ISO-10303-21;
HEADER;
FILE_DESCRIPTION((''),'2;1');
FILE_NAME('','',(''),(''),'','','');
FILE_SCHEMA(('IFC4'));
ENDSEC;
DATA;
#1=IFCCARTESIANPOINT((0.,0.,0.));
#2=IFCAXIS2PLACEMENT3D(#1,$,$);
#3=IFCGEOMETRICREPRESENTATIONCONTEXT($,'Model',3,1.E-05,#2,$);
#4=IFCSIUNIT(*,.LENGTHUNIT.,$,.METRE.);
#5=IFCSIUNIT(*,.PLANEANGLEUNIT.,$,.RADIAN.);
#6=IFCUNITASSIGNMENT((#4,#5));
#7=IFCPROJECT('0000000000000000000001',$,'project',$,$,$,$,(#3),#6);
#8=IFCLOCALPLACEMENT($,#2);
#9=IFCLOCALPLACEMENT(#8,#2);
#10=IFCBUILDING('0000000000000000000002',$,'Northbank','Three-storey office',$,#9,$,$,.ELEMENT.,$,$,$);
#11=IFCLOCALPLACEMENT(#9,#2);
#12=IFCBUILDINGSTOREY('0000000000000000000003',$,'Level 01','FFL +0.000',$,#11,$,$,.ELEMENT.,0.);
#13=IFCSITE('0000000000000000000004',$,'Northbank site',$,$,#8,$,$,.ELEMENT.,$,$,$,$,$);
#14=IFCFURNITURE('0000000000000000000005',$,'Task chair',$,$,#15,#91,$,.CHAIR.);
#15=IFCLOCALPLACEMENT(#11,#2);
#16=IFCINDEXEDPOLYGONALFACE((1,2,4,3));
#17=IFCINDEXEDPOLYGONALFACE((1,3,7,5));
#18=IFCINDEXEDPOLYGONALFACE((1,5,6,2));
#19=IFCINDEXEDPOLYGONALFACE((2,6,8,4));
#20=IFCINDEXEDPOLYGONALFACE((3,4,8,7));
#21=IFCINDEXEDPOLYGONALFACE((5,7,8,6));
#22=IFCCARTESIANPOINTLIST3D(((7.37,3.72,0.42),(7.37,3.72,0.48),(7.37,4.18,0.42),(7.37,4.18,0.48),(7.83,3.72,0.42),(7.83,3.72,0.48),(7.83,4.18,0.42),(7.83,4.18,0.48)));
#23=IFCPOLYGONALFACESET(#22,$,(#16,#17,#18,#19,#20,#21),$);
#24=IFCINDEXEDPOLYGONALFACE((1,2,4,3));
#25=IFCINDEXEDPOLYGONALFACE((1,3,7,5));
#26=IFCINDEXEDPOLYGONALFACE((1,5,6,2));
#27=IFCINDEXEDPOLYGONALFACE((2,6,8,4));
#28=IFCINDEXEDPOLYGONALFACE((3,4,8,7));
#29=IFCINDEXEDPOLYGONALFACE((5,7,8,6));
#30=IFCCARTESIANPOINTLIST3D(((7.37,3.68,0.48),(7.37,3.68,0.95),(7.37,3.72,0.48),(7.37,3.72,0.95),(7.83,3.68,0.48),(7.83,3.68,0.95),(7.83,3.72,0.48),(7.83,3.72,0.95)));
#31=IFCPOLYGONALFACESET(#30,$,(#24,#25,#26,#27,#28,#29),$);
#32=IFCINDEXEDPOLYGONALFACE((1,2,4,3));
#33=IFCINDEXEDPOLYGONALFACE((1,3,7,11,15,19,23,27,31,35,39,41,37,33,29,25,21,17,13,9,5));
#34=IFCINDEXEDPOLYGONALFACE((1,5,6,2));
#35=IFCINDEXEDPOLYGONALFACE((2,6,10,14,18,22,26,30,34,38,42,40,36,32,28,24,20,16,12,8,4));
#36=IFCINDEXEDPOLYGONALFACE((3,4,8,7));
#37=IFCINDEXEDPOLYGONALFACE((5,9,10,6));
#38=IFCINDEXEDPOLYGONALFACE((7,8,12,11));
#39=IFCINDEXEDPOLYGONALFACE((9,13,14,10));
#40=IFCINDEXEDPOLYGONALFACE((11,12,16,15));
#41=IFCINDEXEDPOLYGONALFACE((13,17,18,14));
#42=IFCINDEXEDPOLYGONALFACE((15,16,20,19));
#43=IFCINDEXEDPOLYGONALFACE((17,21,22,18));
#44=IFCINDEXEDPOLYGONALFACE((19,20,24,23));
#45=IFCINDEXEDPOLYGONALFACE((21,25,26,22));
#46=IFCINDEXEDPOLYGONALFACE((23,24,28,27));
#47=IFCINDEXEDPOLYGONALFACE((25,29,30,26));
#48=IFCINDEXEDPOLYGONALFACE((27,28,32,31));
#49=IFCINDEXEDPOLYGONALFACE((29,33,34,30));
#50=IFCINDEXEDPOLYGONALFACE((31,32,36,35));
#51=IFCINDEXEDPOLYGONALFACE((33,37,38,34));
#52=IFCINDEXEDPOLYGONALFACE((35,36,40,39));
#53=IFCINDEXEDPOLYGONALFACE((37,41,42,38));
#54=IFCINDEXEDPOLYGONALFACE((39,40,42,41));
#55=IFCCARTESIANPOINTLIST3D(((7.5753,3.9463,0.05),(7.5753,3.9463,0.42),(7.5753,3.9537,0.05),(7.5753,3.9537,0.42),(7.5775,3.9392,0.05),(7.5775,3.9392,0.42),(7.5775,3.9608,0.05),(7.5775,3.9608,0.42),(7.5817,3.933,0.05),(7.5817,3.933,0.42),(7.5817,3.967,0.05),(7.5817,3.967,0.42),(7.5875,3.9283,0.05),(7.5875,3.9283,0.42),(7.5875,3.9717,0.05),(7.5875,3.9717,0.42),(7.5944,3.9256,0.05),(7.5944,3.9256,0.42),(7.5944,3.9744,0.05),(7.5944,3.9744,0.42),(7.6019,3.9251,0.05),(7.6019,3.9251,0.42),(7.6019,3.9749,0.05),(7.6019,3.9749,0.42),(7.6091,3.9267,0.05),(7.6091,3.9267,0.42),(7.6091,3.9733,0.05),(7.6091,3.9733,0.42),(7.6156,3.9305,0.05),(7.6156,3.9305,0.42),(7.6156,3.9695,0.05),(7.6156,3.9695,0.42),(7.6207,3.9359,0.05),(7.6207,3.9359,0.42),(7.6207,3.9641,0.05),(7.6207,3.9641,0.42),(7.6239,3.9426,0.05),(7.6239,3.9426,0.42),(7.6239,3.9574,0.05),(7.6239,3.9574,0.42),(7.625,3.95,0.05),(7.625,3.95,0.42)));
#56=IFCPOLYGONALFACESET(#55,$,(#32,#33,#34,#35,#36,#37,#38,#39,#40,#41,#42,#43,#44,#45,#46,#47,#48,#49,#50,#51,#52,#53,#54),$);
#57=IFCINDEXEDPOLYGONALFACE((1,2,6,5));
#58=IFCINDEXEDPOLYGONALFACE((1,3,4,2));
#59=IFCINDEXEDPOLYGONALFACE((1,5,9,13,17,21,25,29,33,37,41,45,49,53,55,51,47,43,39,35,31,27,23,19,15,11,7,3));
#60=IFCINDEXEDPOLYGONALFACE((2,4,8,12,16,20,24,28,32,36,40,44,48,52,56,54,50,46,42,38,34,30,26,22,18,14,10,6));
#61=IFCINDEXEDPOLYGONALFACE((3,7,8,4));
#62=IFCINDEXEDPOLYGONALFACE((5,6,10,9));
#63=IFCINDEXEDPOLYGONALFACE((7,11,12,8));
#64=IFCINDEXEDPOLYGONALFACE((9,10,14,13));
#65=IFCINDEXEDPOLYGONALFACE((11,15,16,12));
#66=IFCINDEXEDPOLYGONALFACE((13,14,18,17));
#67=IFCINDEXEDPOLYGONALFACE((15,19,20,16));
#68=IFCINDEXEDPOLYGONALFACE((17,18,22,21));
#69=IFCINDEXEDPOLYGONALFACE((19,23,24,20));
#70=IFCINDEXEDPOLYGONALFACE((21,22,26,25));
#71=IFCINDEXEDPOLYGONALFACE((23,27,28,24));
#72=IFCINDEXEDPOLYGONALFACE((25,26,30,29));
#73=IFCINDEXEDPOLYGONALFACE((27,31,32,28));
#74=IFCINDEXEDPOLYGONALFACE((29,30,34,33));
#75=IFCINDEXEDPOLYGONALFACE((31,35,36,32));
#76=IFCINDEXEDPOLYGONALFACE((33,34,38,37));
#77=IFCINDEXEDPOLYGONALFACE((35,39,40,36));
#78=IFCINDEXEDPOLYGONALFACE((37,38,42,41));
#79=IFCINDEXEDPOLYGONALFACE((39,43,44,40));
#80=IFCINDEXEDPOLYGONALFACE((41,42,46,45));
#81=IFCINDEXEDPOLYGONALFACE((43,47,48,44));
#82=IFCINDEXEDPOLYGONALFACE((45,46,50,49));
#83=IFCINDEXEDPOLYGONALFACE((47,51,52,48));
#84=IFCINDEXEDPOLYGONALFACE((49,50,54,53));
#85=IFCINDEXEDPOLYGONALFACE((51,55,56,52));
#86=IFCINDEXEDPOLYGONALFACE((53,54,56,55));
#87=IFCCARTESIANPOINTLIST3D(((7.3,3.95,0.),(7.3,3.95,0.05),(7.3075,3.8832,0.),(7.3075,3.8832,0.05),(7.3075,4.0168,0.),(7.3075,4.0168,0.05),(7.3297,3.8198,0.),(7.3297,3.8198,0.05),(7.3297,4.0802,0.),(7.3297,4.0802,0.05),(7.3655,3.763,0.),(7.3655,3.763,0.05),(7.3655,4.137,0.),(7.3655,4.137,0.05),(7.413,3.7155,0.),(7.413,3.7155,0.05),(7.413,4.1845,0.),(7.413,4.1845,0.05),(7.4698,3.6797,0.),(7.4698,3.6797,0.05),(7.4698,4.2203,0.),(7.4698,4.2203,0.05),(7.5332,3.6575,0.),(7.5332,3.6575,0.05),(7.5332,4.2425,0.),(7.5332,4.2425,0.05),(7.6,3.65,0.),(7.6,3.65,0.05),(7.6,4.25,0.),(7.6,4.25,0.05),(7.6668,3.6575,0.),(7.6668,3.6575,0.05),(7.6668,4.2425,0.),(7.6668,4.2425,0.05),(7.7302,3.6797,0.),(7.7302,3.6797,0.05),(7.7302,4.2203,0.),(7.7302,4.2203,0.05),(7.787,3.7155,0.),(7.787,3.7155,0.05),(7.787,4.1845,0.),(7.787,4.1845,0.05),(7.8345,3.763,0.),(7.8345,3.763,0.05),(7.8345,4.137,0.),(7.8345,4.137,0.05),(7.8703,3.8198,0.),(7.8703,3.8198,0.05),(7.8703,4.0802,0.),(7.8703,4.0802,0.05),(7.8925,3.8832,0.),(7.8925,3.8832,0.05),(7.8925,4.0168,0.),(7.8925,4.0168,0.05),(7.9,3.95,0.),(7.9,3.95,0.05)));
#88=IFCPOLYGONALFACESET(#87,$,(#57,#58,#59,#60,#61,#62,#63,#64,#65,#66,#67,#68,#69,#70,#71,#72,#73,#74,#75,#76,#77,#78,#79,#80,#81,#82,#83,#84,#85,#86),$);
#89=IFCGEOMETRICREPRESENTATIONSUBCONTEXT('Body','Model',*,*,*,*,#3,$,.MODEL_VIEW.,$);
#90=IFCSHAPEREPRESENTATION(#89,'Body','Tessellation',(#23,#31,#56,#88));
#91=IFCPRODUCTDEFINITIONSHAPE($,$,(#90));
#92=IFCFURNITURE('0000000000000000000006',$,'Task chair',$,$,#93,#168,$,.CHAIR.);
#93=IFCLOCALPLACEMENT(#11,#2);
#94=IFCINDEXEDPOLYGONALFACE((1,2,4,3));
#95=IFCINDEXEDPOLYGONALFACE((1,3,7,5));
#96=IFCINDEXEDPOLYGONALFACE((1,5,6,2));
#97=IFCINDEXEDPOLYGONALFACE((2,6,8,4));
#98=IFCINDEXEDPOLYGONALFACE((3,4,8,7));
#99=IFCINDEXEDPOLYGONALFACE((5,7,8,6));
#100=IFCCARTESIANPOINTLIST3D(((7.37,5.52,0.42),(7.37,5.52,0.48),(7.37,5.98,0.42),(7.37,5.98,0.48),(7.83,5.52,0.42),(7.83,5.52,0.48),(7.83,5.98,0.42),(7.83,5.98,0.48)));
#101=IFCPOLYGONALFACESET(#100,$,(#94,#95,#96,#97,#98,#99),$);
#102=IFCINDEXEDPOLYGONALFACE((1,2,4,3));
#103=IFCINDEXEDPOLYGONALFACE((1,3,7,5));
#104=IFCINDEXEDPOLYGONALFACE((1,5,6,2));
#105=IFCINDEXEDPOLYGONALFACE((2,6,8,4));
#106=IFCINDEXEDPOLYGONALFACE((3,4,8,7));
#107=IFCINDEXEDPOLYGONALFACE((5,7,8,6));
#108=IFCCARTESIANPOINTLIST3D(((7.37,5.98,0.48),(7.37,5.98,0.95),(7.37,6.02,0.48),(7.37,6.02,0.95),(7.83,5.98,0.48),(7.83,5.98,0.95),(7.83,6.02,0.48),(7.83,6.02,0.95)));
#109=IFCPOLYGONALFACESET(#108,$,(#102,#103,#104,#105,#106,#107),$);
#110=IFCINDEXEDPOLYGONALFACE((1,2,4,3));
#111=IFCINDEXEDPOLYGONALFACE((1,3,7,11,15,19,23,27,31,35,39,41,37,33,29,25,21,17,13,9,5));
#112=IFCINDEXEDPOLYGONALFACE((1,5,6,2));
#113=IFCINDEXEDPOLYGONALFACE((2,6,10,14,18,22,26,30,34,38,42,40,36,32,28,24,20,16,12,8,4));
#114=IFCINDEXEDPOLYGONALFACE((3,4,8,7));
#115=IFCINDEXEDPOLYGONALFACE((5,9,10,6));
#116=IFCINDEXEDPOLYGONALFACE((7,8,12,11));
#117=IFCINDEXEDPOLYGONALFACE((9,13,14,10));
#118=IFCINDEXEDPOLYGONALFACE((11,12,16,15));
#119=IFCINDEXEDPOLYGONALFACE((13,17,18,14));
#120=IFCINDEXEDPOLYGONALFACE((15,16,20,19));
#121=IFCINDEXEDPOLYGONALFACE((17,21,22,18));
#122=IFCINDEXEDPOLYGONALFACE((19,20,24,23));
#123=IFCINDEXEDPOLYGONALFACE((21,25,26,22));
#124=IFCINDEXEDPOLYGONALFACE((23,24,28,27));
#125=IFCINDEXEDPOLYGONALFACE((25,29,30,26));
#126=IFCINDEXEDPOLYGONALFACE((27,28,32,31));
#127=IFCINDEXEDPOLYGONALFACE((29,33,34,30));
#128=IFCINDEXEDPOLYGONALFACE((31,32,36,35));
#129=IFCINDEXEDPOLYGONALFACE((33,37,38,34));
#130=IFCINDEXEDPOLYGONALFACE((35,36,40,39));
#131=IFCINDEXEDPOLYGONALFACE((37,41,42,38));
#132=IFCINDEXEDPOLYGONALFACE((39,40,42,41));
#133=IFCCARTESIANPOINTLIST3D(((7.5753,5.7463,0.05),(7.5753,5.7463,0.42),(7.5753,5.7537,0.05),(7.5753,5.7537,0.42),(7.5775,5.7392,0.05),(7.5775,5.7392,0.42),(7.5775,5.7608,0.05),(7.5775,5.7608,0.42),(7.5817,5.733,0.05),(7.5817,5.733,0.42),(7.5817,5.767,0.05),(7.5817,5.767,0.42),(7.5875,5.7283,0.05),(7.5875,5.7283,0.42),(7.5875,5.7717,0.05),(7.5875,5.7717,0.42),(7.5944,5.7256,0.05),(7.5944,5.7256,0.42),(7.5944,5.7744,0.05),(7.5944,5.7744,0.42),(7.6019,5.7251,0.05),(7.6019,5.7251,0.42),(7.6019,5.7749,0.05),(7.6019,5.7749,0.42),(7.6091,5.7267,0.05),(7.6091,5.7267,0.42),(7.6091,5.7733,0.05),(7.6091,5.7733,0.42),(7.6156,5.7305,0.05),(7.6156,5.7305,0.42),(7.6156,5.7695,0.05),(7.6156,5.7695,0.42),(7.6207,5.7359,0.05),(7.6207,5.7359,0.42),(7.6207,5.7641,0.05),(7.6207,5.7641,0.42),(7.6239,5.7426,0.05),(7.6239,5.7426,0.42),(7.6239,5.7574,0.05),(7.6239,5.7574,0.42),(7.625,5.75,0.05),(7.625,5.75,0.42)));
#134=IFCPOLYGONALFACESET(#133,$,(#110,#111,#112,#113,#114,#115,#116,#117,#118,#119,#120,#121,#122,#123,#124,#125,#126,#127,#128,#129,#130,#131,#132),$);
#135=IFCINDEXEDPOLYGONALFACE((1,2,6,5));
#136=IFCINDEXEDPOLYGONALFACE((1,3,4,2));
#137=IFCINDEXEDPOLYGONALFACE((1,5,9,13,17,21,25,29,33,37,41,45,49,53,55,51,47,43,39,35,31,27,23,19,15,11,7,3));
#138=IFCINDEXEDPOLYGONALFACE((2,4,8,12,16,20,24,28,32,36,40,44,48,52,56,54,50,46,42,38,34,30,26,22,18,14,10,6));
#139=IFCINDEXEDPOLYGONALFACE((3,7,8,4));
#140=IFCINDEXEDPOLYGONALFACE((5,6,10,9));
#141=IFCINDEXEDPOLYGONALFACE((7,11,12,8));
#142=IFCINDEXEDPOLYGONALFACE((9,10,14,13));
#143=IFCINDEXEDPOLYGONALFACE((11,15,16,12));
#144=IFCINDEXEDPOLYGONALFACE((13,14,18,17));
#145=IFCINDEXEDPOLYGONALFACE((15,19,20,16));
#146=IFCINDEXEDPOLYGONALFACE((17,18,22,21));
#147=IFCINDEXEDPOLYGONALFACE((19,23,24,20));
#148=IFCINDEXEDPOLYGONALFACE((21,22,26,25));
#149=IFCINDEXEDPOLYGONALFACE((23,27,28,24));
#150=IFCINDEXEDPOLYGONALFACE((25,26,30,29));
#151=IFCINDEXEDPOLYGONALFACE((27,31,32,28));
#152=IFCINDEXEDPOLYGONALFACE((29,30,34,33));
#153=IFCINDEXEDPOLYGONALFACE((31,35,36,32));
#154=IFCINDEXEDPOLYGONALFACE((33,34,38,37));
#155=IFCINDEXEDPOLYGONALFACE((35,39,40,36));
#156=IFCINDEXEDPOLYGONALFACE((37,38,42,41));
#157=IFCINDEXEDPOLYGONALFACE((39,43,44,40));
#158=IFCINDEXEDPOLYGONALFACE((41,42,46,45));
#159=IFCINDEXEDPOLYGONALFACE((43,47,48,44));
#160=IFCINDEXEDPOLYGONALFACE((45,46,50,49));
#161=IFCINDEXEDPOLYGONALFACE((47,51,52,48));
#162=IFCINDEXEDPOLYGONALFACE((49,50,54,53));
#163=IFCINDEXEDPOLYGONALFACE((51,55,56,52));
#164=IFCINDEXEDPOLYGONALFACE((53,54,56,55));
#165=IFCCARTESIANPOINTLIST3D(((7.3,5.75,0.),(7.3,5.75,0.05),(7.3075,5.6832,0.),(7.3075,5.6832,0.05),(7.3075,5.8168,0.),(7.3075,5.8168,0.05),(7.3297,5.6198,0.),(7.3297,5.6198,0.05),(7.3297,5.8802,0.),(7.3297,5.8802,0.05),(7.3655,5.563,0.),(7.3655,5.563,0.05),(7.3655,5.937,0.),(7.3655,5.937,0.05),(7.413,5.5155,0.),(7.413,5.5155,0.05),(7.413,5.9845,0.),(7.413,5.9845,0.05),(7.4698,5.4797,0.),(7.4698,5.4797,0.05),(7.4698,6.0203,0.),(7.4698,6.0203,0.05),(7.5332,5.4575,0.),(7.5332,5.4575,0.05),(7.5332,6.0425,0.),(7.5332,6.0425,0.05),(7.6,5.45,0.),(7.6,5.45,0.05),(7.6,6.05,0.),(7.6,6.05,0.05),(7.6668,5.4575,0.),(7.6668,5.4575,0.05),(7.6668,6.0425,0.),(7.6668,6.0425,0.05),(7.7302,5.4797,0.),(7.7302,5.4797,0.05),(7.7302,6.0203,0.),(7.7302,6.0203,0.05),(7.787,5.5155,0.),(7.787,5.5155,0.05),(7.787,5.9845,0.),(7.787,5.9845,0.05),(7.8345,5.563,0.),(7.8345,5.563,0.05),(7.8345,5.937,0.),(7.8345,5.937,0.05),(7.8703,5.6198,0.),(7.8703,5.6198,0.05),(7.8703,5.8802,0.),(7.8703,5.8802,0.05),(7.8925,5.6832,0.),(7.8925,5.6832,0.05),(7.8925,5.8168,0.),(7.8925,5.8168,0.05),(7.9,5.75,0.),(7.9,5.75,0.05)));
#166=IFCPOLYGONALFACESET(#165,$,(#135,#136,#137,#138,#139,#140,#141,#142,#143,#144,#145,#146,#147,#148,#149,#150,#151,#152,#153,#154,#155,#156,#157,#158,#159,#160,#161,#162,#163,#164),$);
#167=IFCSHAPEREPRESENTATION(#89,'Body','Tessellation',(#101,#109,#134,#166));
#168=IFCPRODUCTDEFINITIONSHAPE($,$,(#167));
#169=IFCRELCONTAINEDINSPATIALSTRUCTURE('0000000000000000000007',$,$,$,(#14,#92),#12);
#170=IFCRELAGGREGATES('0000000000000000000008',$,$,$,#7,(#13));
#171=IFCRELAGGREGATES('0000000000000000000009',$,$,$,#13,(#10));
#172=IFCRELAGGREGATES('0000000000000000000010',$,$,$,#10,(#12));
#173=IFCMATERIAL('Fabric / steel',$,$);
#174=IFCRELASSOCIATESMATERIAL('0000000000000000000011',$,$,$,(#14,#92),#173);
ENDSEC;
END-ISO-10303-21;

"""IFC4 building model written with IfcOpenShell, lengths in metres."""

from ifc_helpers import new_model, si_unit, frame, origin, place, context, subcontext, project, spatial, rectangle, circle, extrude, material, element, save


model = new_model("IFC4")

# Units and contexts
model_context = context("Model", 3, precision=1e-05, world=origin())
body_context = subcontext(model_context, "Body", "Model", "MODEL_VIEW")
ifc_project = project(units=[si_unit("LENGTHUNIT", "METRE"), si_unit("PLANEANGLEUNIT", "RADIAN")], contexts=[model_context])

# Site, building, storey
site_placement = place(None, origin())
site = spatial("IfcSite", under=ifc_project, at=site_placement, Name="Northbank site", CompositionType="ELEMENT")
building_placement = place(site_placement, origin())
building = spatial("IfcBuilding", under=site, at=building_placement, Name="Northbank", Description="Three-storey office", CompositionType="ELEMENT")
storey_placement = place(building_placement, origin())
storey = spatial("IfcBuildingStorey", under=building, at=storey_placement, Name="Level 01", Description="FFL +0.000", CompositionType="ELEMENT", Elevation=0.0)

# Furniture
ifc_material_1 = material(Name="Fabric / steel")
furniture_1_placement = place(storey_placement, origin())
element("IfcFurniture", 1, at=furniture_1_placement, inside=storey, material=ifc_material_1, Name="Task chair", PredefinedType="CHAIR", context=body_context, shape_type="SweptSolid", body=[
    extrude(rectangle(XDim=0.46, YDim=0.46), frame((7.6, 3.95, 0.42)), (0.0, 0.0, 1.0), 0.06),
    extrude(rectangle(XDim=0.46, YDim=0.04), frame((7.6, 3.7, 0.48)), (0.0, 0.0, 1.0), 0.47),
    extrude(circle(Radius=0.025), frame((7.6, 3.95, 0.05), z_axis=(0.0, 0.0, 1.0), x_axis=(1.0, 0.0, 0.0)), (0.0, 0.0, 1.0), 0.37),
    extrude(circle(Radius=0.3), frame((7.6, 3.95, 0.0), z_axis=(0.0, 0.0, 1.0), x_axis=(1.0, 0.0, 0.0)), (0.0, 0.0, 1.0), 0.05),
])
furniture_2_placement = place(storey_placement, origin())
element("IfcFurniture", 2, at=furniture_2_placement, inside=storey, material=ifc_material_1, Name="Task chair", PredefinedType="CHAIR", context=body_context, shape_type="SweptSolid", body=[
    extrude(rectangle(XDim=0.46, YDim=0.46), frame((7.6, 5.75, 0.42)), (0.0, 0.0, 1.0), 0.06),
    extrude(rectangle(XDim=0.46, YDim=0.04), frame((7.6, 6.0, 0.48)), (0.0, 0.0, 1.0), 0.47),
    extrude(circle(Radius=0.025), frame((7.6, 5.75, 0.05), z_axis=(0.0, 0.0, 1.0), x_axis=(1.0, 0.0, 0.0)), (0.0, 0.0, 1.0), 0.37),
    extrude(circle(Radius=0.3), frame((7.6, 5.75, 0.0), z_axis=(0.0, 0.0, 1.0), x_axis=(1.0, 0.0, 0.0)), (0.0, 0.0, 1.0), 0.05),
])

save(model, "model.ifc")
